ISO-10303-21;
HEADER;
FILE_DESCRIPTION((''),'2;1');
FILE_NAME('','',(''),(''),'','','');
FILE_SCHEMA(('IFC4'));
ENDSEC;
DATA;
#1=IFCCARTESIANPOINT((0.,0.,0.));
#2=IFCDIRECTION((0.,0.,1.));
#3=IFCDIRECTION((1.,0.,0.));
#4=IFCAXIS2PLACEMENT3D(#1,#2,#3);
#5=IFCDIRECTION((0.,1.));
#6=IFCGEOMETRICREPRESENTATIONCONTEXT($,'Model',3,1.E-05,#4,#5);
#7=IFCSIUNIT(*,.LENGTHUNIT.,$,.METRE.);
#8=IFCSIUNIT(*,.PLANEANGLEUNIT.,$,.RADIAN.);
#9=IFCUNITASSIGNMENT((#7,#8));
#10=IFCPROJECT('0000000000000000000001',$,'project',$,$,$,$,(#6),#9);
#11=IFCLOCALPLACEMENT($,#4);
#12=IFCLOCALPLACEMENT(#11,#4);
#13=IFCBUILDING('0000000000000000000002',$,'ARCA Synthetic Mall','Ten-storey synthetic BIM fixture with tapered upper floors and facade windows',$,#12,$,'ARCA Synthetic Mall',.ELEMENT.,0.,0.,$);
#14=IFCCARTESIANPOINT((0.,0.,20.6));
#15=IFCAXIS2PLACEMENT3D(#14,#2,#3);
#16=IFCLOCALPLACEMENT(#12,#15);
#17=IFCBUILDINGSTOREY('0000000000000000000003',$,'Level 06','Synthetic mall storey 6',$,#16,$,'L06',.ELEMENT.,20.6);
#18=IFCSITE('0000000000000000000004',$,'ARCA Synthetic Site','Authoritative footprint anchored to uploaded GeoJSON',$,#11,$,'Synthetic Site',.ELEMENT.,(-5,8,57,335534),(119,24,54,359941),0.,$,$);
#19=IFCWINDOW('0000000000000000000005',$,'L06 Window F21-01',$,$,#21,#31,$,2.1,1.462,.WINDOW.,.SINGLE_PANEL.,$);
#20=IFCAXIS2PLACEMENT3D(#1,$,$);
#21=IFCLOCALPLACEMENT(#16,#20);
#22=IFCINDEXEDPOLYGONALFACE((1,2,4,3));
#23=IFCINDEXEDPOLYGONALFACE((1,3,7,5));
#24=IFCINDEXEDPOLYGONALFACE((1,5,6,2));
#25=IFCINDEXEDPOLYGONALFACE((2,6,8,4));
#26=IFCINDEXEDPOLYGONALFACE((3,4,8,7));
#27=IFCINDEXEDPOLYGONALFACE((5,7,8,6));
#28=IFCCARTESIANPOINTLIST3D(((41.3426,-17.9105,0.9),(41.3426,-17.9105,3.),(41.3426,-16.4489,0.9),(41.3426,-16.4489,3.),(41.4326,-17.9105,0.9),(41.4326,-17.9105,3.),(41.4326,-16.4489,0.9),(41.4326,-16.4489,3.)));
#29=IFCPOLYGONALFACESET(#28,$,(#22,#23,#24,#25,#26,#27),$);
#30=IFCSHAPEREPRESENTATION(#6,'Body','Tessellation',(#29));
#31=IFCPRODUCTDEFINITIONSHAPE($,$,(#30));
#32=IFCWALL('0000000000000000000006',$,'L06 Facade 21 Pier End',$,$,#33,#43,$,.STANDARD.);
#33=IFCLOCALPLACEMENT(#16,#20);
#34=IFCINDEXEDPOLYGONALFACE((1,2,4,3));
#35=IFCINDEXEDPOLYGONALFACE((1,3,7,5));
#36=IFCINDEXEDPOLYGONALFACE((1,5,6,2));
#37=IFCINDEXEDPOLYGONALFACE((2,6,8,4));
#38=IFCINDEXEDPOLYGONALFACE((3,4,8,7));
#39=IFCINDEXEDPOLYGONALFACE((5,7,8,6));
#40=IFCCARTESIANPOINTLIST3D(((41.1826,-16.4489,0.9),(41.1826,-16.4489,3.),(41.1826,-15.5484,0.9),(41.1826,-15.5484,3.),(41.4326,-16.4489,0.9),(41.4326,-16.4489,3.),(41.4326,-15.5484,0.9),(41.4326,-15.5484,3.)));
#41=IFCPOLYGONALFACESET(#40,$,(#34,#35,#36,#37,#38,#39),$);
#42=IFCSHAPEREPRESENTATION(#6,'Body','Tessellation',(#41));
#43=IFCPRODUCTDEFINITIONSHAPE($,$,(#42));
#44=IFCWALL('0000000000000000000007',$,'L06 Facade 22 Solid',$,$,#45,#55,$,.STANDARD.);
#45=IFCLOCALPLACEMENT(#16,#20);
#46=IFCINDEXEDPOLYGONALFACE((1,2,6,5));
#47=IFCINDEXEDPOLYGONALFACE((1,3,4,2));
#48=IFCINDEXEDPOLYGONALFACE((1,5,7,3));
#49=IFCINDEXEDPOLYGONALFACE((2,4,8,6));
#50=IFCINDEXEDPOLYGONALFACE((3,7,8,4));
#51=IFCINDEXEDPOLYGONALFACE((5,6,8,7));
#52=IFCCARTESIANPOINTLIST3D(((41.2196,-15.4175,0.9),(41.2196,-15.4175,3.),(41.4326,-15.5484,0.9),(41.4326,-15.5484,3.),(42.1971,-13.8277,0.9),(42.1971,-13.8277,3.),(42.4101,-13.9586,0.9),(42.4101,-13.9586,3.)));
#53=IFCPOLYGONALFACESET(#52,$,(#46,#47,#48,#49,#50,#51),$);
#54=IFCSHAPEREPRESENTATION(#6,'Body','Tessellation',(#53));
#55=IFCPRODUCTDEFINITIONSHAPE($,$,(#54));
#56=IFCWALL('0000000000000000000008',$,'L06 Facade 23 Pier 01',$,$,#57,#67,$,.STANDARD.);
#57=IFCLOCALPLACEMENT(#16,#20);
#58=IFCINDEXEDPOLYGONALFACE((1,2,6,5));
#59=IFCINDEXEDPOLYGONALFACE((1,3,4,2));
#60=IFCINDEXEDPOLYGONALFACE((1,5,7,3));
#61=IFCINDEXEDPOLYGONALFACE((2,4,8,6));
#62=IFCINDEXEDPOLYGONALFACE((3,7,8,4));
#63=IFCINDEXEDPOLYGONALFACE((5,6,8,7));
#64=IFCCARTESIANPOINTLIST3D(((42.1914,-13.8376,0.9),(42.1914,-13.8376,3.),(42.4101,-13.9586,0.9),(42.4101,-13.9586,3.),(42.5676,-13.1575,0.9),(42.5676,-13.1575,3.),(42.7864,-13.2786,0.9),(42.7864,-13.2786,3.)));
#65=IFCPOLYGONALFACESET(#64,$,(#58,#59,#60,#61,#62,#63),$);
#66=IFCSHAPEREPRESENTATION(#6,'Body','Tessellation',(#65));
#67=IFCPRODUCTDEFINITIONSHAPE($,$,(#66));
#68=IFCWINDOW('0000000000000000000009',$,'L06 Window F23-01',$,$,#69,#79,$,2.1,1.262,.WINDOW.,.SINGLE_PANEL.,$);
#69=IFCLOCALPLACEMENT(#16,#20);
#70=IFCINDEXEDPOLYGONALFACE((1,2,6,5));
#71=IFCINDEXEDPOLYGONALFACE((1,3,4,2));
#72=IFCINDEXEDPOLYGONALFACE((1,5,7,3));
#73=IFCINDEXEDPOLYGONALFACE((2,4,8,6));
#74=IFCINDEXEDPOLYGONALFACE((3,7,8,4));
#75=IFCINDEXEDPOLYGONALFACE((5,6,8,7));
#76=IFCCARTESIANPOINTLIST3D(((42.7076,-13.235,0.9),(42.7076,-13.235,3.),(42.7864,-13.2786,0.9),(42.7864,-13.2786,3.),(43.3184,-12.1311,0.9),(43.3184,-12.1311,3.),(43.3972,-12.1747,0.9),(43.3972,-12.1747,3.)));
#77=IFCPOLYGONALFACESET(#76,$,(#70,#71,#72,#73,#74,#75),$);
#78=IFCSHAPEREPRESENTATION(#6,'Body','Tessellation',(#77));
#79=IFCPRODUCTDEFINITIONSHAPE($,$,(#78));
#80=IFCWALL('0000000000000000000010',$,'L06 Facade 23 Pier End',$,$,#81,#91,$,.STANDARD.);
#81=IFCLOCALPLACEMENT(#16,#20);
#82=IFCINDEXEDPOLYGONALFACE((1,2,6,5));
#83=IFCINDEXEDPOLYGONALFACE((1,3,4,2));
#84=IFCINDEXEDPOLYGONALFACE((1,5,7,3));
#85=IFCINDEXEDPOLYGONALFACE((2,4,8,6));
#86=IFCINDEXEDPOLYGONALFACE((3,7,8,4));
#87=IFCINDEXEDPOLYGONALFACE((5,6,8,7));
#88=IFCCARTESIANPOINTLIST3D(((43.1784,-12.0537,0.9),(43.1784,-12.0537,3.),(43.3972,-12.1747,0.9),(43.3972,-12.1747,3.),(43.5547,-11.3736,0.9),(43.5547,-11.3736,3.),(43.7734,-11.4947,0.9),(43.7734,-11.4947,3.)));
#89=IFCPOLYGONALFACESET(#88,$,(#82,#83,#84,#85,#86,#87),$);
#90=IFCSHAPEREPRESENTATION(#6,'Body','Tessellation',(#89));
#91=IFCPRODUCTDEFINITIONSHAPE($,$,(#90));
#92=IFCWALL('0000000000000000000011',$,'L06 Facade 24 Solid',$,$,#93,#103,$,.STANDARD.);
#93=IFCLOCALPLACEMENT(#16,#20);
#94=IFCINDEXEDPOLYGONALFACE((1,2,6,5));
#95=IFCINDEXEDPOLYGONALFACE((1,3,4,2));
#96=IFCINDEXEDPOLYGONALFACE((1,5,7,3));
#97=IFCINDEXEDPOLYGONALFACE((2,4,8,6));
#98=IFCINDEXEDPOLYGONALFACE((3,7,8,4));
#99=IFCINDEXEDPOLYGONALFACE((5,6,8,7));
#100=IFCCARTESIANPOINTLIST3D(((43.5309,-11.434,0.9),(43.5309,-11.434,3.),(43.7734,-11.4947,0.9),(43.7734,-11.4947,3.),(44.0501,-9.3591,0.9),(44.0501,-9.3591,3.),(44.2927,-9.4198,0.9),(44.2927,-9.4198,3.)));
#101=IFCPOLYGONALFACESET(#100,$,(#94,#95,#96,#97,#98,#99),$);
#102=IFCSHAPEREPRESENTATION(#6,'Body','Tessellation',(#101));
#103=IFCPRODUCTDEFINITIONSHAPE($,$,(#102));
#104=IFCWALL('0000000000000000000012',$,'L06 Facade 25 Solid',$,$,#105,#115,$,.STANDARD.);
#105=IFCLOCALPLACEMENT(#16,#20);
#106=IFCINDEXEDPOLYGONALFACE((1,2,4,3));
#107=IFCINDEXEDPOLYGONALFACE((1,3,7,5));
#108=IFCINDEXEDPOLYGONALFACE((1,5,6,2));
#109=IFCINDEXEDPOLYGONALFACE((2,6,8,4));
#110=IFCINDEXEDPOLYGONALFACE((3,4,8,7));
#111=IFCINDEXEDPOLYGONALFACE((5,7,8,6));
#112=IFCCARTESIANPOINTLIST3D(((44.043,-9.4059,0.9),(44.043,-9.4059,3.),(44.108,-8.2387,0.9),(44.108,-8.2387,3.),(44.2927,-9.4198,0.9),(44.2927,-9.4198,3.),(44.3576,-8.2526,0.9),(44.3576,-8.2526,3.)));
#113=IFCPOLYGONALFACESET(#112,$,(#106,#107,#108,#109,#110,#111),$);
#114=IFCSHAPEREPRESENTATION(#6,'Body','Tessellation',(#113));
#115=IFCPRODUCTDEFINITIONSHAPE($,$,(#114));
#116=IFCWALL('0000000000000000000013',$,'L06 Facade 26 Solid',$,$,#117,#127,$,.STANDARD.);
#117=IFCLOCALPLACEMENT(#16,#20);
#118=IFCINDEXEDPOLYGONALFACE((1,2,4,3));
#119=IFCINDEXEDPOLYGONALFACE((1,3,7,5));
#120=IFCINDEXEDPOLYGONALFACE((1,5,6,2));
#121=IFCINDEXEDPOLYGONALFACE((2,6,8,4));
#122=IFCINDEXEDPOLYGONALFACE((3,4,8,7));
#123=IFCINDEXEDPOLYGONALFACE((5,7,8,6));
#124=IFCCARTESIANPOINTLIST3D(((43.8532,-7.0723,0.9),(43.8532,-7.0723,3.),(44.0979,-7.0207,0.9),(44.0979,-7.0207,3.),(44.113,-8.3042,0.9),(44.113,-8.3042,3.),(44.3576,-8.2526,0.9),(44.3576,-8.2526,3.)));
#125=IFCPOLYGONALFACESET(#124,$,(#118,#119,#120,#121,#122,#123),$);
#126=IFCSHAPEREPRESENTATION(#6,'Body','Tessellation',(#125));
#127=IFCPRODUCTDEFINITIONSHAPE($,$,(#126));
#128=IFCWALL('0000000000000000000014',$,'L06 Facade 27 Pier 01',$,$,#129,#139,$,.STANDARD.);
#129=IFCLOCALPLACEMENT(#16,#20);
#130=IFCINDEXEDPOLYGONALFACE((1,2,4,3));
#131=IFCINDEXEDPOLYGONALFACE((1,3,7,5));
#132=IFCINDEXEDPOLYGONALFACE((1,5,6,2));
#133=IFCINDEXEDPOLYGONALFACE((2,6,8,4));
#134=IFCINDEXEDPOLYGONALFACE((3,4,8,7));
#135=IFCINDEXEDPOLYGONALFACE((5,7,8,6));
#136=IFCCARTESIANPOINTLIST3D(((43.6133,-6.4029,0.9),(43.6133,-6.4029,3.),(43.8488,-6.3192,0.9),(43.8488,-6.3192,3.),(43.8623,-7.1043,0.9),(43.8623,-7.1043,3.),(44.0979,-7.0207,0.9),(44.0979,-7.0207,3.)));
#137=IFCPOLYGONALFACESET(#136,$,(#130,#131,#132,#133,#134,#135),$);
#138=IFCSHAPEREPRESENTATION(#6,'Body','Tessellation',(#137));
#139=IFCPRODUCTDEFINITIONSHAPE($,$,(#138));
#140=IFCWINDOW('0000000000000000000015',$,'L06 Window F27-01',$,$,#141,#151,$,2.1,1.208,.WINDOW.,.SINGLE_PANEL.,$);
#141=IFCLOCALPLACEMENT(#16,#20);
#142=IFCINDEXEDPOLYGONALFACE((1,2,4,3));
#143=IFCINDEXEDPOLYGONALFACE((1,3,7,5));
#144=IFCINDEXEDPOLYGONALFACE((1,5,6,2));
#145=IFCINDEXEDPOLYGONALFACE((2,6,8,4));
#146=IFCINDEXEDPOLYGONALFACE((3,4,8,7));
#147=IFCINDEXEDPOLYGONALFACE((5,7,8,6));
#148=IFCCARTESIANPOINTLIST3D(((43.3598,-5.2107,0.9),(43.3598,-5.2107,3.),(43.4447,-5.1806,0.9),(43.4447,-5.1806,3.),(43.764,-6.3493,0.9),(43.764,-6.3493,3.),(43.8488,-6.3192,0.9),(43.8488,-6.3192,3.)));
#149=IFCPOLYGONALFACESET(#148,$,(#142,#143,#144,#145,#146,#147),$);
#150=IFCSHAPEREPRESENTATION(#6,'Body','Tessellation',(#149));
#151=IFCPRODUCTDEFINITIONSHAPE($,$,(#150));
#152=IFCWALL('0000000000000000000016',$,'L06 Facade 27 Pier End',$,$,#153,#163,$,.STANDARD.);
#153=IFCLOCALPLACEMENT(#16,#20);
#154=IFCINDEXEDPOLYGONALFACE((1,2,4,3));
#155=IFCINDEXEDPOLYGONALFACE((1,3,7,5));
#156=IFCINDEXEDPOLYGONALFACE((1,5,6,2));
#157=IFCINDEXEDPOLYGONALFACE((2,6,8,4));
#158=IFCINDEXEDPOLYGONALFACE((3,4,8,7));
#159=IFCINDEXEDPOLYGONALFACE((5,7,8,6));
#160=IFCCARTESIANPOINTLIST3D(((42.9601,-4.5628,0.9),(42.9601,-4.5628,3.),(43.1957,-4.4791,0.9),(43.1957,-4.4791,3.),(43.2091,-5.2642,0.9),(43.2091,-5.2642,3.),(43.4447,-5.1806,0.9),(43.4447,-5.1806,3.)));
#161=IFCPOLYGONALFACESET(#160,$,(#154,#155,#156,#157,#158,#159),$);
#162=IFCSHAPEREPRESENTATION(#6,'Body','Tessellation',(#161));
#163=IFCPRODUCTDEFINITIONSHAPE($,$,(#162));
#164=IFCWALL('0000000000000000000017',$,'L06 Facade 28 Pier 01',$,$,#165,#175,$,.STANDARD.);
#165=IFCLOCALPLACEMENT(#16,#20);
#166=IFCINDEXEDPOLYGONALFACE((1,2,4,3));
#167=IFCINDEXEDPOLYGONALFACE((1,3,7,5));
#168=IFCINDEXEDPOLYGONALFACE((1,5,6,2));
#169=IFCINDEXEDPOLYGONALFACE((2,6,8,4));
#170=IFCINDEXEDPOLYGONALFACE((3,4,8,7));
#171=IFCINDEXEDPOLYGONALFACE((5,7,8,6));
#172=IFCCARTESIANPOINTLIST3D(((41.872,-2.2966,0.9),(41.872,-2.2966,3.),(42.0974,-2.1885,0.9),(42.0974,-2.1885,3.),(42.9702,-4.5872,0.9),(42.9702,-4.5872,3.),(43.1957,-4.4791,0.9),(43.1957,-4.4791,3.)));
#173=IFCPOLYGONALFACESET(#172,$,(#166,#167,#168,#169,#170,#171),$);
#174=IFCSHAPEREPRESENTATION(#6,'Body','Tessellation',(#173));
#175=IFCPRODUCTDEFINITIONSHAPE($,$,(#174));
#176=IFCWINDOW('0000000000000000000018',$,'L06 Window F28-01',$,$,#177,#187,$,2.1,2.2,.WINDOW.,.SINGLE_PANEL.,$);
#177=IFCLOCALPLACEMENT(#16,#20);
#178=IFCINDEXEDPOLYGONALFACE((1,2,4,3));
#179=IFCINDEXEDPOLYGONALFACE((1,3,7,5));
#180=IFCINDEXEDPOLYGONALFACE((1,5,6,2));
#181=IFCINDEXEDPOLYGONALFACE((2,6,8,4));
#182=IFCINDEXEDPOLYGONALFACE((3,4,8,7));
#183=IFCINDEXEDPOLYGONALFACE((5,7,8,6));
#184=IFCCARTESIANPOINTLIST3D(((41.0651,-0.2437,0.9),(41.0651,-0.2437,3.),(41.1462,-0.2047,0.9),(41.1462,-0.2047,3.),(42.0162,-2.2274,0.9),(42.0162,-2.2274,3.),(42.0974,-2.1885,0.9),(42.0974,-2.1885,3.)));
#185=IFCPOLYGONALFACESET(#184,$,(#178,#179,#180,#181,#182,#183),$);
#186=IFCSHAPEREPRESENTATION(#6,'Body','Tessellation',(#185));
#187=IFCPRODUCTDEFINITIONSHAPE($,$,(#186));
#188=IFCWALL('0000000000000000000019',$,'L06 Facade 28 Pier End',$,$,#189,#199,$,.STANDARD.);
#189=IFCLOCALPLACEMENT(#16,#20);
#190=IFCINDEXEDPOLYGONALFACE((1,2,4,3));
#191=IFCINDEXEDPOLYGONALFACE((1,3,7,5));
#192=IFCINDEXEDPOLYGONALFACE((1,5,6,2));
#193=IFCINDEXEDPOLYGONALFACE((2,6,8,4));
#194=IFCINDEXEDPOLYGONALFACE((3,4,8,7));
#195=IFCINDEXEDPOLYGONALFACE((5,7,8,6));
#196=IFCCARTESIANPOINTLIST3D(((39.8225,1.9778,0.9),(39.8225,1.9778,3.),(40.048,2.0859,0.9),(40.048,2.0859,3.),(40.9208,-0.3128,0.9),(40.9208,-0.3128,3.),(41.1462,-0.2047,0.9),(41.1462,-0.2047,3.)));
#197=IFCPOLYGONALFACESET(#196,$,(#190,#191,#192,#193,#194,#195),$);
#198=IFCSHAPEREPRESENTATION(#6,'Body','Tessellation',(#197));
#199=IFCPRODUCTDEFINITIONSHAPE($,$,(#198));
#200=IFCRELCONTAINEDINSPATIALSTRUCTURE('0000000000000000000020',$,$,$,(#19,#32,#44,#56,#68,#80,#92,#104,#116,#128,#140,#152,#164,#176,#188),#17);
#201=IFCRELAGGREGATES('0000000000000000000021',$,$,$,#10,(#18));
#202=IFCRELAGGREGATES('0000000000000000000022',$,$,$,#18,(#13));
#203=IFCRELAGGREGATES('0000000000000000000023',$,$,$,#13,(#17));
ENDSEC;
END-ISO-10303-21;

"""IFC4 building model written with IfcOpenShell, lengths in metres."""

from ifc_helpers import new_model, si_unit, direction, frame, origin_with_axes, place, context, project, spatial, polyline, outline, extrude, element, save


model = new_model("IFC4")

# Units and contexts
model_context = context("Model", 3, precision=1e-05, world=origin_with_axes(), true_north=direction((0.0, 1.0)))
ifc_project = project(units=[si_unit("LENGTHUNIT", "METRE"), si_unit("PLANEANGLEUNIT", "RADIAN")], contexts=[model_context])

# Site, building, storey
site_placement = place(None, origin_with_axes())
site = spatial("IfcSite", under=ifc_project, at=site_placement, Name="ARCA Synthetic Site", Description="Authoritative footprint anchored to uploaded GeoJSON", LongName="Synthetic Site", CompositionType="ELEMENT", RefLatitude=(-5, 8, 57, 335534), RefLongitude=(119, 24, 54, 359941), RefElevation=0.0)
building_placement = place(site_placement, origin_with_axes())
building = spatial("IfcBuilding", under=site, at=building_placement, Name="ARCA Synthetic Mall", Description="Ten-storey synthetic BIM fixture with tapered upper floors and facade windows", LongName="ARCA Synthetic Mall", CompositionType="ELEMENT", ElevationOfRefHeight=0.0, ElevationOfTerrain=0.0)
storey_placement = place(building_placement, frame((0.0, 0.0, 20.6), z_axis=(0.0, 0.0, 1.0), x_axis=(1.0, 0.0, 0.0)))
storey = spatial("IfcBuildingStorey", under=building, at=storey_placement, Name="Level 06", Description="Synthetic mall storey 6", LongName="L06", CompositionType="ELEMENT", Elevation=20.6)

# Window
window_1_placement = place(storey_placement, frame((0.0, 0.0, 0.9), z_axis=(0.0, 0.0, 1.0), x_axis=(1.0, 0.0, 0.0)))
element("IfcWindow", 1, at=window_1_placement, inside=storey, Name="L06 Window F21-01", OverallHeight=2.1, OverallWidth=1.462, PartitioningType="SINGLE_PANEL", PredefinedType="WINDOW", context=model_context, shape_type="SweptSolid", body=[
    extrude(outline(polyline([(41.4326, -17.9105), (41.4326, -16.4489), (41.3426, -16.4489), (41.3426, -17.9105), (41.4326, -17.9105)])), origin_with_axes(), (0.0, 0.0, 1.0), 2.1),
])

# Walls
wall_1_placement = place(storey_placement, frame((0.0, 0.0, 0.9), z_axis=(0.0, 0.0, 1.0), x_axis=(1.0, 0.0, 0.0)))
element("IfcWall", 2, at=wall_1_placement, inside=storey, Name="L06 Facade 21 Pier End", PredefinedType="STANDARD", context=model_context, shape_type="SweptSolid", body=[
    extrude(outline(polyline([(41.4326, -16.4489), (41.4326, -15.5484), (41.1826, -15.5484), (41.1826, -16.4489), (41.4326, -16.4489)])), origin_with_axes(), (0.0, 0.0, 1.0), 2.1),
])
wall_2_placement = place(storey_placement, frame((0.0, 0.0, 0.9), z_axis=(0.0, 0.0, 1.0), x_axis=(1.0, 0.0, 0.0)))
element("IfcWall", 3, at=wall_2_placement, inside=storey, Name="L06 Facade 22 Solid", PredefinedType="STANDARD", context=model_context, shape_type="SweptSolid", body=[
    extrude(outline(polyline([(41.4326, -15.5484), (42.4101, -13.9586), (42.1971, -13.8277), (41.2196, -15.4175), (41.4326, -15.5484)])), origin_with_axes(), (0.0, 0.0, 1.0), 2.1),
])
wall_3_placement = place(storey_placement, frame((0.0, 0.0, 0.9), z_axis=(0.0, 0.0, 1.0), x_axis=(1.0, 0.0, 0.0)))
element("IfcWall", 4, at=wall_3_placement, inside=storey, Name="L06 Facade 23 Pier 01", PredefinedType="STANDARD", context=model_context, shape_type="SweptSolid", body=[
    extrude(outline(polyline([(42.4101, -13.9586), (42.7864, -13.2786), (42.5676, -13.1575), (42.1914, -13.8376), (42.4101, -13.9586)])), origin_with_axes(), (0.0, 0.0, 1.0), 2.1),
])

# Window
window_2_placement = place(storey_placement, frame((0.0, 0.0, 0.9), z_axis=(0.0, 0.0, 1.0), x_axis=(1.0, 0.0, 0.0)))
element("IfcWindow", 5, at=window_2_placement, inside=storey, Name="L06 Window F23-01", OverallHeight=2.1, OverallWidth=1.262, PartitioningType="SINGLE_PANEL", PredefinedType="WINDOW", context=model_context, shape_type="SweptSolid", body=[
    extrude(outline(polyline([(42.7864, -13.2786), (43.3972, -12.1747), (43.3184, -12.1311), (42.7076, -13.235), (42.7864, -13.2786)])), origin_with_axes(), (0.0, 0.0, 1.0), 2.1),
])

# Walls
wall_4_placement = place(storey_placement, frame((0.0, 0.0, 0.9), z_axis=(0.0, 0.0, 1.0), x_axis=(1.0, 0.0, 0.0)))
element("IfcWall", 6, at=wall_4_placement, inside=storey, Name="L06 Facade 23 Pier End", PredefinedType="STANDARD", context=model_context, shape_type="SweptSolid", body=[
    extrude(outline(polyline([(43.3972, -12.1747), (43.7734, -11.4947), (43.5547, -11.3736), (43.1784, -12.0537), (43.3972, -12.1747)])), origin_with_axes(), (0.0, 0.0, 1.0), 2.1),
])
wall_5_placement = place(storey_placement, frame((0.0, 0.0, 0.9), z_axis=(0.0, 0.0, 1.0), x_axis=(1.0, 0.0, 0.0)))
element("IfcWall", 7, at=wall_5_placement, inside=storey, Name="L06 Facade 24 Solid", PredefinedType="STANDARD", context=model_context, shape_type="SweptSolid", body=[
    extrude(outline(polyline([(43.7734, -11.4947), (44.2927, -9.4198), (44.0501, -9.3591), (43.5309, -11.434), (43.7734, -11.4947)])), origin_with_axes(), (0.0, 0.0, 1.0), 2.1),
])
wall_6_placement = place(storey_placement, frame((0.0, 0.0, 0.9), z_axis=(0.0, 0.0, 1.0), x_axis=(1.0, 0.0, 0.0)))
element("IfcWall", 8, at=wall_6_placement, inside=storey, Name="L06 Facade 25 Solid", PredefinedType="STANDARD", context=model_context, shape_type="SweptSolid", body=[
    extrude(outline(polyline([(44.2927, -9.4198), (44.3576, -8.2526), (44.108, -8.2387), (44.043, -9.4059), (44.2927, -9.4198)])), origin_with_axes(), (0.0, 0.0, 1.0), 2.1),
])
wall_7_placement = place(storey_placement, frame((0.0, 0.0, 0.9), z_axis=(0.0, 0.0, 1.0), x_axis=(1.0, 0.0, 0.0)))
element("IfcWall", 9, at=wall_7_placement, inside=storey, Name="L06 Facade 26 Solid", PredefinedType="STANDARD", context=model_context, shape_type="SweptSolid", body=[
    extrude(outline(polyline([(44.3576, -8.2526), (44.0979, -7.0207), (43.8532, -7.0723), (44.113, -8.3042), (44.3576, -8.2526)])), origin_with_axes(), (0.0, 0.0, 1.0), 2.1),
])
wall_8_placement = place(storey_placement, frame((0.0, 0.0, 0.9), z_axis=(0.0, 0.0, 1.0), x_axis=(1.0, 0.0, 0.0)))
element("IfcWall", 10, at=wall_8_placement, inside=storey, Name="L06 Facade 27 Pier 01", PredefinedType="STANDARD", context=model_context, shape_type="SweptSolid", body=[
    extrude(outline(polyline([(44.0979, -7.0207), (43.8488, -6.3192), (43.6133, -6.4029), (43.8623, -7.1043), (44.0979, -7.0207)])), origin_with_axes(), (0.0, 0.0, 1.0), 2.1),
])

# Window
window_3_placement = place(storey_placement, frame((0.0, 0.0, 0.9), z_axis=(0.0, 0.0, 1.0), x_axis=(1.0, 0.0, 0.0)))
element("IfcWindow", 11, at=window_3_placement, inside=storey, Name="L06 Window F27-01", OverallHeight=2.1, OverallWidth=1.208, PartitioningType="SINGLE_PANEL", PredefinedType="WINDOW", context=model_context, shape_type="SweptSolid", body=[
    extrude(outline(polyline([(43.8488, -6.3192), (43.4447, -5.1806), (43.3598, -5.2107), (43.764, -6.3493), (43.8488, -6.3192)])), origin_with_axes(), (0.0, 0.0, 1.0), 2.1),
])

# Walls
wall_9_placement = place(storey_placement, frame((0.0, 0.0, 0.9), z_axis=(0.0, 0.0, 1.0), x_axis=(1.0, 0.0, 0.0)))
element("IfcWall", 12, at=wall_9_placement, inside=storey, Name="L06 Facade 27 Pier End", PredefinedType="STANDARD", context=model_context, shape_type="SweptSolid", body=[
    extrude(outline(polyline([(43.4447, -5.1806), (43.1957, -4.4791), (42.9601, -4.5628), (43.2091, -5.2642), (43.4447, -5.1806)])), origin_with_axes(), (0.0, 0.0, 1.0), 2.1),
])
wall_10_placement = place(storey_placement, frame((0.0, 0.0, 0.9), z_axis=(0.0, 0.0, 1.0), x_axis=(1.0, 0.0, 0.0)))
element("IfcWall", 13, at=wall_10_placement, inside=storey, Name="L06 Facade 28 Pier 01", PredefinedType="STANDARD", context=model_context, shape_type="SweptSolid", body=[
    extrude(outline(polyline([(43.1957, -4.4791), (42.0974, -2.1885), (41.872, -2.2966), (42.9702, -4.5872), (43.1957, -4.4791)])), origin_with_axes(), (0.0, 0.0, 1.0), 2.1),
])

# Window
window_4_placement = place(storey_placement, frame((0.0, 0.0, 0.9), z_axis=(0.0, 0.0, 1.0), x_axis=(1.0, 0.0, 0.0)))
element("IfcWindow", 14, at=window_4_placement, inside=storey, Name="L06 Window F28-01", OverallHeight=2.1, OverallWidth=2.2, PartitioningType="SINGLE_PANEL", PredefinedType="WINDOW", context=model_context, shape_type="SweptSolid", body=[
    extrude(outline(polyline([(42.0974, -2.1885), (41.1462, -0.2047), (41.0651, -0.2437), (42.0162, -2.2274), (42.0974, -2.1885)])), origin_with_axes(), (0.0, 0.0, 1.0), 2.1),
])

# Wall
wall_11_placement = place(storey_placement, frame((0.0, 0.0, 0.9), z_axis=(0.0, 0.0, 1.0), x_axis=(1.0, 0.0, 0.0)))
element("IfcWall", 15, at=wall_11_placement, inside=storey, Name="L06 Facade 28 Pier End", PredefinedType="STANDARD", context=model_context, shape_type="SweptSolid", body=[
    extrude(outline(polyline([(41.1462, -0.2047), (40.048, 2.0859), (39.8225, 1.9778), (40.9208, -0.3128), (41.1462, -0.2047)])), origin_with_axes(), (0.0, 0.0, 1.0), 2.1),
])

save(model, "model.ifc")
